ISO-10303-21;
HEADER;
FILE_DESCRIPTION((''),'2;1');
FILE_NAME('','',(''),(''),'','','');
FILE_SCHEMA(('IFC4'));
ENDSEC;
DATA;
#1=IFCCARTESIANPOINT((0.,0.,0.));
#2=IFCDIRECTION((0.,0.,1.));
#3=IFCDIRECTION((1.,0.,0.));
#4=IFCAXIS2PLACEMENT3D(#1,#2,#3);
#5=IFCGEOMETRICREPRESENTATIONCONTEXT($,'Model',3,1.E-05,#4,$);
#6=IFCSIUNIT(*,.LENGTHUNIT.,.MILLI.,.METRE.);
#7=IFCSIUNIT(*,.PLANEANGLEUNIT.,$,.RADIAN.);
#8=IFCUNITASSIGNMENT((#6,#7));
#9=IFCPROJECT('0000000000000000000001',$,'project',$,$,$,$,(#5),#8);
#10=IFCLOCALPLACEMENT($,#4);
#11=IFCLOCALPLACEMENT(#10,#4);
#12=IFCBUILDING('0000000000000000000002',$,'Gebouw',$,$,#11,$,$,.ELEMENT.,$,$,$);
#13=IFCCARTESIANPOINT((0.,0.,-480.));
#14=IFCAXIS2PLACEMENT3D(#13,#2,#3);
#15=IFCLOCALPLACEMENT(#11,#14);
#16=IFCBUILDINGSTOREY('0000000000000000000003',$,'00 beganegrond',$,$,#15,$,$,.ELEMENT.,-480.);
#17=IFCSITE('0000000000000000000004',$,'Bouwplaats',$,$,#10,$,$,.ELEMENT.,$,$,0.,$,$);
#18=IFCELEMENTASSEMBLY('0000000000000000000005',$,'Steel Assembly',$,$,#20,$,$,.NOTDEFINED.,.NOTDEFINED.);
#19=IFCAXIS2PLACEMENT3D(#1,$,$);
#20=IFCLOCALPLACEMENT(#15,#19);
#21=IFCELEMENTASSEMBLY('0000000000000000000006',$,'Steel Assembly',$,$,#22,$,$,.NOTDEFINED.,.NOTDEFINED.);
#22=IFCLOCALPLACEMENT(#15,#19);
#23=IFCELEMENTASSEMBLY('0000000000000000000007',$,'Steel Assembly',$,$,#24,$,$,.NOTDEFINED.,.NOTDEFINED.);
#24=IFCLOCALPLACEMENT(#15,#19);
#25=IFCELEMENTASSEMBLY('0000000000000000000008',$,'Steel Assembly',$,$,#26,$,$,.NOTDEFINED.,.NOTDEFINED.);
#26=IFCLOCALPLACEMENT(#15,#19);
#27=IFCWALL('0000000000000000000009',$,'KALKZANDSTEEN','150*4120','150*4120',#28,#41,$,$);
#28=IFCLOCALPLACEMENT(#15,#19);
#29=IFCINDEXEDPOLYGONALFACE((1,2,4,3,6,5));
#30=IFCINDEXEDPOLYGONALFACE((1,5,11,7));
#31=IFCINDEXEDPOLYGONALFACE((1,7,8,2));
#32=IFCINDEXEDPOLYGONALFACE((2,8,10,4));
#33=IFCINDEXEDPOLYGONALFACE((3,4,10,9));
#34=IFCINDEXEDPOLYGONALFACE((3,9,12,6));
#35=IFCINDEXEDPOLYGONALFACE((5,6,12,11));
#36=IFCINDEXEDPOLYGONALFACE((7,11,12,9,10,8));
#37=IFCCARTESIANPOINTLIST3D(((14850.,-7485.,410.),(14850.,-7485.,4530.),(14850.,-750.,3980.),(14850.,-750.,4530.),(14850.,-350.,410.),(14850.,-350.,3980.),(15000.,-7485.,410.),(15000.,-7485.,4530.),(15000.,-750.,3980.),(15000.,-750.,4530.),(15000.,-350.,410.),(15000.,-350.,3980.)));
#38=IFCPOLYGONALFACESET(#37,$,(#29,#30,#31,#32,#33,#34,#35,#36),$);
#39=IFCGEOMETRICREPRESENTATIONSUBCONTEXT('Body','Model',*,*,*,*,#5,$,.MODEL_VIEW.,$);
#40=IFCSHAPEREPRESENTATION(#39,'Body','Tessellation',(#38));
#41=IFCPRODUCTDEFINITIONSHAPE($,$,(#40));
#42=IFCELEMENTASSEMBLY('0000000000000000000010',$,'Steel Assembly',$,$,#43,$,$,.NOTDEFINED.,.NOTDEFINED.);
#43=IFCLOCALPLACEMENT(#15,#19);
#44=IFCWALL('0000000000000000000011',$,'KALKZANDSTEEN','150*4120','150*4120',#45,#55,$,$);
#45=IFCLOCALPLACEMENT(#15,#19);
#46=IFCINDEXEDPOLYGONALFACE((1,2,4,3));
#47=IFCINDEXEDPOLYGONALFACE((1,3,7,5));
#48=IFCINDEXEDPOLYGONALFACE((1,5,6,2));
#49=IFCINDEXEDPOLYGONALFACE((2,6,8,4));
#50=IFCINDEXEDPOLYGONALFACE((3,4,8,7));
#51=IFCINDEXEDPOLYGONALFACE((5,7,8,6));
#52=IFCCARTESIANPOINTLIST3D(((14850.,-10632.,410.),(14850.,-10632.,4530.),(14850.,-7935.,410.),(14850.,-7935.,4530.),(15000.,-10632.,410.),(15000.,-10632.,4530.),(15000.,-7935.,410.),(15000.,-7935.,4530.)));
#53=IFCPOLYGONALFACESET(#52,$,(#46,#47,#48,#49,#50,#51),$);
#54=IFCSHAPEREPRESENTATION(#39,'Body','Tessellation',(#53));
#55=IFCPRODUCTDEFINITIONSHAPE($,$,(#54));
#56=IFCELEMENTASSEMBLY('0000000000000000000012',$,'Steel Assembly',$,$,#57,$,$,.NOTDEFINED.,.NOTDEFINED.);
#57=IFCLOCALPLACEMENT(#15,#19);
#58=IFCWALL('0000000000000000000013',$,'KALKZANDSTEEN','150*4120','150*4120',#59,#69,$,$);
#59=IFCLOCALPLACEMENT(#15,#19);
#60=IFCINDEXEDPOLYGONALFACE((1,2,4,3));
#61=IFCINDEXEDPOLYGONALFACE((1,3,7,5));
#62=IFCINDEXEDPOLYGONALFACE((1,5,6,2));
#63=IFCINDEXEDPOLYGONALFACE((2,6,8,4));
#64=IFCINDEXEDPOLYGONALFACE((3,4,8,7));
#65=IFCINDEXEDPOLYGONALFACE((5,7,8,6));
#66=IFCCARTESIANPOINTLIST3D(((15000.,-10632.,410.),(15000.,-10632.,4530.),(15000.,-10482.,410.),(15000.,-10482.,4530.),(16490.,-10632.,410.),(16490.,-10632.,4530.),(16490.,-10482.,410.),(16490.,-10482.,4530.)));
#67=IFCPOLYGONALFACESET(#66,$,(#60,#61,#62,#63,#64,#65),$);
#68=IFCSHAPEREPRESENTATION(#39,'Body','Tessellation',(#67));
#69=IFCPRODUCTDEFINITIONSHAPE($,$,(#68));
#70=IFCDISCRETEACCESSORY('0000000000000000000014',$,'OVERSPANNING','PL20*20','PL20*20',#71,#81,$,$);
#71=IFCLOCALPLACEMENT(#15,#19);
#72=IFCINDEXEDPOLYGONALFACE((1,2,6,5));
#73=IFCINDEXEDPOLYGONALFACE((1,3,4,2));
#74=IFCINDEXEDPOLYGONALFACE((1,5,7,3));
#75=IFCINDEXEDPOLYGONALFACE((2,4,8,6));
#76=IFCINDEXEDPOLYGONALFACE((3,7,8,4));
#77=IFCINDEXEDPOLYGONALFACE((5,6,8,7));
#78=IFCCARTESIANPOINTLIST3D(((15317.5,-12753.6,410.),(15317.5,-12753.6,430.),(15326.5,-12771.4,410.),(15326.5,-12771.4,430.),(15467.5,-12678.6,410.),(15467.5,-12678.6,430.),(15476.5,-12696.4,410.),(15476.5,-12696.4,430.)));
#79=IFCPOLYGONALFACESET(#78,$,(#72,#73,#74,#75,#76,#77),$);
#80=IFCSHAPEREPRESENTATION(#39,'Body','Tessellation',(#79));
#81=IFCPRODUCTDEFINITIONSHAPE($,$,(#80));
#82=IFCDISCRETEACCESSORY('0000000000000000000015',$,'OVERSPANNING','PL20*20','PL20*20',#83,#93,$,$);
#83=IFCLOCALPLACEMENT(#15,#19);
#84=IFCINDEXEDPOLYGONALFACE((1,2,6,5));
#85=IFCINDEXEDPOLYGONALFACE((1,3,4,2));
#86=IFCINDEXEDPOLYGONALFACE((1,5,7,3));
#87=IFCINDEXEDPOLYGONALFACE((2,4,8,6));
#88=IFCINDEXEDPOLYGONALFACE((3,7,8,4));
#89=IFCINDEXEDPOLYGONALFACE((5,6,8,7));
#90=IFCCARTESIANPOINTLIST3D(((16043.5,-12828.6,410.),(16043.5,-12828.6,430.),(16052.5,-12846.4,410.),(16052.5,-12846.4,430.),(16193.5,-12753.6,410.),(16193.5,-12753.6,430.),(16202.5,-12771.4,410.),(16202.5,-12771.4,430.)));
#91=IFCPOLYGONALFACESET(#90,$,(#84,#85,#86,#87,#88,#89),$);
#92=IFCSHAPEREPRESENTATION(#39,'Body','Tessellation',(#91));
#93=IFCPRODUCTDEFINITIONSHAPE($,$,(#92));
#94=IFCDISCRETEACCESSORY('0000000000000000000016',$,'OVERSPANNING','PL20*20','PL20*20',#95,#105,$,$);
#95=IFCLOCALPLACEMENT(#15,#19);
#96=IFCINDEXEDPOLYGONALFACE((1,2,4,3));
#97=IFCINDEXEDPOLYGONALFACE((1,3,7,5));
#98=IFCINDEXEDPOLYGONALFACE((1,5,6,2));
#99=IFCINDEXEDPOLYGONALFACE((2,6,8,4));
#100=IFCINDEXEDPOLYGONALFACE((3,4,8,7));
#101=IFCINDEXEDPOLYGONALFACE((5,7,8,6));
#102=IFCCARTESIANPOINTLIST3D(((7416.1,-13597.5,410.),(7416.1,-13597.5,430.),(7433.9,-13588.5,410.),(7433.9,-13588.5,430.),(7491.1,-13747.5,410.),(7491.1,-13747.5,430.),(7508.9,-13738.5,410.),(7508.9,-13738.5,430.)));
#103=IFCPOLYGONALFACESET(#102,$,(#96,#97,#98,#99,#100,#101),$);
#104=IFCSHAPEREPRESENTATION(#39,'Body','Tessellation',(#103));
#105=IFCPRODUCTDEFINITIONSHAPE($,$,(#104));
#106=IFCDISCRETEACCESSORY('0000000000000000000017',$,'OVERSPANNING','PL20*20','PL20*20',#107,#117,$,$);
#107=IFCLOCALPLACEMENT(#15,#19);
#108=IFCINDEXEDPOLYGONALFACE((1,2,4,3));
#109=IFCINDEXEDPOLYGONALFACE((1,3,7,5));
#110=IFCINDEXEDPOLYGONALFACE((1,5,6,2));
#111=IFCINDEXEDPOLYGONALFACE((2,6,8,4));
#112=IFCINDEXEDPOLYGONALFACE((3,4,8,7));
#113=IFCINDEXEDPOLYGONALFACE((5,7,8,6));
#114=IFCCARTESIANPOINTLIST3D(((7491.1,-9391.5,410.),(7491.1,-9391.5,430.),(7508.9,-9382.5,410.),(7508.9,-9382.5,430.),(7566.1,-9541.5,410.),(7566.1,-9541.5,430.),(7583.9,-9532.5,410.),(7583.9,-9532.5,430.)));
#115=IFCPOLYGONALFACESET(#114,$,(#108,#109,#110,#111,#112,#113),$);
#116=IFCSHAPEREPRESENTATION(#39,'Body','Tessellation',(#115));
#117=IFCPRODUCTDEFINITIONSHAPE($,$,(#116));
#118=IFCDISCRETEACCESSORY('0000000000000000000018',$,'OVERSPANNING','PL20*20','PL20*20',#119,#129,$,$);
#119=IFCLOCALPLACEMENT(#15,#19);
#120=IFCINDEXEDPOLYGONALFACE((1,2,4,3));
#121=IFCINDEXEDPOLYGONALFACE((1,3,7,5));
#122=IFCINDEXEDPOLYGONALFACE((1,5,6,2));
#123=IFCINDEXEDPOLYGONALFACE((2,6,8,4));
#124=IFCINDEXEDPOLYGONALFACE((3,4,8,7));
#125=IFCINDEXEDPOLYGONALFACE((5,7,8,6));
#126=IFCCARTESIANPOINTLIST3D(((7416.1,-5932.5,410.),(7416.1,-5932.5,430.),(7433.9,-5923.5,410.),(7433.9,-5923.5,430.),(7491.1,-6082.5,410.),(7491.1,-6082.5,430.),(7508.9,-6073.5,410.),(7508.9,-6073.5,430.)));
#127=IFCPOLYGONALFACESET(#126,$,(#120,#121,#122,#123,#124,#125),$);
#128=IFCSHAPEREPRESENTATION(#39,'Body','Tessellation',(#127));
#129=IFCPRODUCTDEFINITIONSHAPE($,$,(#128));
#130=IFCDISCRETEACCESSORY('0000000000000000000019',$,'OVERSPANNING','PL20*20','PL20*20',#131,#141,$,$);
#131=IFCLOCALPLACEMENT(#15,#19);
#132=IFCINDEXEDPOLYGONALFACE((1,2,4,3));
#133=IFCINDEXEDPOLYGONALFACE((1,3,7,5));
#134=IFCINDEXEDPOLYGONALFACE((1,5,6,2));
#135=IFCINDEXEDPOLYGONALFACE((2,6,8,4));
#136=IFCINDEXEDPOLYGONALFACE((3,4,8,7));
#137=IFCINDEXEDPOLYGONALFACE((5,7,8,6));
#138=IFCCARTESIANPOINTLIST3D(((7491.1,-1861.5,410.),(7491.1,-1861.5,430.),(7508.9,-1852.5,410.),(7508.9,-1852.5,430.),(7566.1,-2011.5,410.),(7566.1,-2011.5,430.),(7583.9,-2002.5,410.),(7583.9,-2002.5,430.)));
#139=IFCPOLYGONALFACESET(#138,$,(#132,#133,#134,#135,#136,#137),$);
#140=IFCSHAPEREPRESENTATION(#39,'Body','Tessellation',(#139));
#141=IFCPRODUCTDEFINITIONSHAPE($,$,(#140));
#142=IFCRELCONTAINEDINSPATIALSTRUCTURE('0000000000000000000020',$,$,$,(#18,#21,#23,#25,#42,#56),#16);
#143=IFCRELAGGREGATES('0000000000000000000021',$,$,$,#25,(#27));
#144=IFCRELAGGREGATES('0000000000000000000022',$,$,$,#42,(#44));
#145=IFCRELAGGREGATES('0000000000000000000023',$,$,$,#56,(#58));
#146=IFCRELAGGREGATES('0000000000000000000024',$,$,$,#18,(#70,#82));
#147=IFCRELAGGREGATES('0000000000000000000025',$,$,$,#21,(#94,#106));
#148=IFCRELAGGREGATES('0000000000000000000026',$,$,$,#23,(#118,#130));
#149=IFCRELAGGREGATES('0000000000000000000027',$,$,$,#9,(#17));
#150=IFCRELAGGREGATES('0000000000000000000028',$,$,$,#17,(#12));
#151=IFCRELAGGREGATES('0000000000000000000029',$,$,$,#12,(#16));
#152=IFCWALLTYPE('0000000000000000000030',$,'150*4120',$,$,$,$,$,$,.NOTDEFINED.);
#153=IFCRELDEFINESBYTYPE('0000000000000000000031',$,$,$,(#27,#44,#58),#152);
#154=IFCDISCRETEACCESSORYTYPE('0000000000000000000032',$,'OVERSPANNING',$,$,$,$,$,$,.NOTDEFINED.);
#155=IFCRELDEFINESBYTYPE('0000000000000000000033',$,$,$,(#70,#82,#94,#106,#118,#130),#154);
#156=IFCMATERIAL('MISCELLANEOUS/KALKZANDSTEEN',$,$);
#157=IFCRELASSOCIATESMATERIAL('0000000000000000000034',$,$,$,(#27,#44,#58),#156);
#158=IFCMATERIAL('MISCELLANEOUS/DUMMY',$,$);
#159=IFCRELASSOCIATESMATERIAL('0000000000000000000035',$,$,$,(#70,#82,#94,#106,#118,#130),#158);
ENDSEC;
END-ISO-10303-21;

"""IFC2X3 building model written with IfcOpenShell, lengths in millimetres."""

from ifc_helpers import new_model, si_unit, frame, frame_2d, origin_with_axes, origin_2d_with_axis, place, context, subcontext, project, spatial, rectangle, extrude, boolean, material, type_object, element, aggregate, save


model = new_model("IFC2X3")

# Units and contexts
model_context = context("Model", 3, precision=1e-05, world=origin_with_axes())
body_context = subcontext(model_context, "Body", "Model", "MODEL_VIEW")
ifc_project = project(units=[si_unit("LENGTHUNIT", "METRE", prefix="MILLI"), si_unit("PLANEANGLEUNIT", "RADIAN")], contexts=[model_context])

# Site, building, storey
site_placement = place(None, origin_with_axes())
site = spatial("IfcSite", under=ifc_project, at=site_placement, Name="Bouwplaats", CompositionType="ELEMENT", RefElevation=0.0)
building_placement = place(site_placement, origin_with_axes())
building = spatial("IfcBuilding", under=site, at=building_placement, Name="Gebouw", CompositionType="ELEMENT")
storey_placement = place(building_placement, frame((0.0, 0.0, -480.0), z_axis=(0.0, 0.0, 1.0), x_axis=(1.0, 0.0, 0.0)))
storey = spatial("IfcBuildingStorey", under=building, at=storey_placement, Name="00 beganegrond", CompositionType="ELEMENT", Elevation=-480.0)

# Element assemblies
ifc_material_1 = material(Name="MISCELLANEOUS/DUMMY")
assembly_1_placement = place(storey_placement, origin_with_axes())
assembly_1 = element("IfcElementAssembly", 1, at=assembly_1_placement, inside=storey, Name="Steel Assembly", AssemblyPlace="NOTDEFINED", PredefinedType="NOTDEFINED")
assembly_2_placement = place(storey_placement, origin_with_axes())
assembly_2 = element("IfcElementAssembly", 2, at=assembly_2_placement, inside=storey, Name="Steel Assembly", AssemblyPlace="NOTDEFINED", PredefinedType="NOTDEFINED")
assembly_3_placement = place(storey_placement, origin_with_axes())
assembly_3 = element("IfcElementAssembly", 3, at=assembly_3_placement, inside=storey, Name="Steel Assembly", AssemblyPlace="NOTDEFINED", PredefinedType="NOTDEFINED")

# Element assemblies, walls
ifc_material_2 = material(Name="MISCELLANEOUS/KALKZANDSTEEN")
assembly_4_placement = place(storey_placement, origin_with_axes())
assembly_4 = element("IfcElementAssembly", 4, at=assembly_4_placement, inside=storey, Name="Steel Assembly", AssemblyPlace="NOTDEFINED", PredefinedType="NOTDEFINED")
wall_type_1 = type_object("IfcWallType", Name="150*4120", PredefinedType="NOTDEFINED")
wall_1_placement = place(assembly_4_placement, frame((14925.0, -7485.0, 410.0), z_axis=(0.0, 0.0, 1.0), x_axis=(0.0, 1.0, 0.0)))
wall_1 = element("IfcWall", 5, at=wall_1_placement, type_object=wall_type_1, material=ifc_material_2, Name="KALKZANDSTEEN", Description="150*4120", ObjectType="150*4120", context=body_context, shape_type="CSG", body=[
    boolean("DIFFERENCE", extrude(rectangle(XDim=7135.0, YDim=150.0, at=frame_2d((0.0, 3567.5), x_axis=(0.0, -1.0))), frame((0.0, 0.0, 0.0), z_axis=(0.0, 0.0, 1.0), x_axis=(0.0, -1.0, 0.0)), (0.0, 0.0, 1.0), 4120.0), extrude(rectangle(XDim=150.0, YDim=550.0, at=origin_2d_with_axis()), frame((6735.0, 0.0, 3845.0), z_axis=(1.0, 0.0, 0.0), x_axis=(0.0, 1.0, 0.0)), (0.0, 0.0, 1.0), 400.0)),
])
aggregate(assembly_4, [wall_1])
assembly_5_placement = place(storey_placement, origin_with_axes())
assembly_5 = element("IfcElementAssembly", 6, at=assembly_5_placement, inside=storey, Name="Steel Assembly", AssemblyPlace="NOTDEFINED", PredefinedType="NOTDEFINED")
wall_2_placement = place(assembly_5_placement, frame((14925.0, -10632.0, 410.0), z_axis=(0.0, 0.0, 1.0), x_axis=(0.0, 1.0, 0.0)))
wall_2 = element("IfcWall", 7, at=wall_2_placement, type_object=wall_type_1, material=ifc_material_2, Name="KALKZANDSTEEN", Description="150*4120", ObjectType="150*4120", context=body_context, shape_type="SweptSolid", body=[
    extrude(rectangle(XDim=2697.0, YDim=150.0, at=frame_2d((0.0, 1348.5), x_axis=(0.0, -1.0))), frame((0.0, 0.0, 0.0), z_axis=(0.0, 0.0, 1.0), x_axis=(0.0, -1.0, 0.0)), (0.0, 0.0, 1.0), 4120.0),
])
aggregate(assembly_5, [wall_2])
assembly_6_placement = place(storey_placement, origin_with_axes())
assembly_6 = element("IfcElementAssembly", 8, at=assembly_6_placement, inside=storey, Name="Steel Assembly", AssemblyPlace="NOTDEFINED", PredefinedType="NOTDEFINED")
wall_3_placement = place(assembly_6_placement, frame((15000.0, -10557.0, 410.0), z_axis=(0.0, 0.0, 1.0), x_axis=(1.0, 0.0, 0.0)))
wall_3 = element("IfcWall", 9, at=wall_3_placement, type_object=wall_type_1, material=ifc_material_2, Name="KALKZANDSTEEN", Description="150*4120", ObjectType="150*4120", context=body_context, shape_type="SweptSolid", body=[
    extrude(rectangle(XDim=1490.0, YDim=150.0, at=frame_2d((0.0, 745.0), x_axis=(0.0, -1.0))), frame((0.0, 0.0, 0.0), z_axis=(0.0, 0.0, 1.0), x_axis=(0.0, -1.0, 0.0)), (0.0, 0.0, 1.0), 4120.0),
])
aggregate(assembly_6, [wall_3])

# Discrete accessories
discrete_accessory_type = type_object("IfcDiscreteAccessoryType", Name="OVERSPANNING")
discrete_accessory_1_placement = place(assembly_1_placement, frame((15472.0, -12687.5, 420.0), z_axis=(0.447214, -0.894427, 0.0), x_axis=(-0.894427, -0.447214, 0.0)))
discrete_accessory_1 = element("IfcDiscreteAccessory", 10, at=discrete_accessory_1_placement, type_object=discrete_accessory_type, material=ifc_material_1, Name="OVERSPANNING", Description="PL20*20", ObjectType="PL20*20", context=body_context, shape_type="SweptSolid", body=[
    extrude(rectangle(XDim=20.0, YDim=20.0, at=origin_2d_with_axis()), frame((167.7, 0.0, 0.0), z_axis=(-1.0, 0.0, 0.0), x_axis=(0.0, -1.0, 0.0)), (0.0, 0.0, 1.0), 167.7),
])
discrete_accessory_2_placement = place(assembly_1_placement, frame((16048.0, -12837.5, 420.0), z_axis=(-0.447214, 0.894427, 0.0), x_axis=(0.894427, 0.447214, 0.0)))
discrete_accessory_2 = element("IfcDiscreteAccessory", 11, at=discrete_accessory_2_placement, type_object=discrete_accessory_type, material=ifc_material_1, Name="OVERSPANNING", Description="PL20*20", ObjectType="PL20*20", context=body_context, shape_type="SweptSolid", body=[
    extrude(rectangle(XDim=20.0, YDim=20.0, at=origin_2d_with_axis()), frame((167.7, 0.0, 0.0), z_axis=(-1.0, 0.0, 0.0), x_axis=(0.0, -1.0, 0.0)), (0.0, 0.0, 1.0), 167.7),
])
aggregate(assembly_1, [discrete_accessory_1, discrete_accessory_2])
discrete_accessory_3_placement = place(assembly_2_placement, frame((7425.0, -13593.0, 420.0), z_axis=(0.894427, 0.447214, 0.0), x_axis=(0.447214, -0.894427, 0.0)))
discrete_accessory_3 = element("IfcDiscreteAccessory", 12, at=discrete_accessory_3_placement, type_object=discrete_accessory_type, material=ifc_material_1, Name="OVERSPANNING", Description="PL20*20", ObjectType="PL20*20", context=body_context, shape_type="SweptSolid", body=[
    extrude(rectangle(XDim=20.0, YDim=20.0, at=origin_2d_with_axis()), frame((167.7, 0.0, 0.0), z_axis=(-1.0, 0.0, 0.0), x_axis=(0.0, -1.0, 0.0)), (0.0, 0.0, 1.0), 167.7),
])
discrete_accessory_4_placement = place(assembly_2_placement, frame((7575.0, -9537.0, 420.0), z_axis=(-0.894427, -0.447214, 0.0), x_axis=(-0.447214, 0.894427, 0.0)))
discrete_accessory_4 = element("IfcDiscreteAccessory", 13, at=discrete_accessory_4_placement, type_object=discrete_accessory_type, material=ifc_material_1, Name="OVERSPANNING", Description="PL20*20", ObjectType="PL20*20", context=body_context, shape_type="SweptSolid", body=[
    extrude(rectangle(XDim=20.0, YDim=20.0, at=origin_2d_with_axis()), frame((167.7, 0.0, 0.0), z_axis=(-1.0, 0.0, 0.0), x_axis=(0.0, -1.0, 0.0)), (0.0, 0.0, 1.0), 167.7),
])
aggregate(assembly_2, [discrete_accessory_3, discrete_accessory_4])
discrete_accessory_5_placement = place(assembly_3_placement, frame((7425.0, -5928.0, 420.0), z_axis=(0.894427, 0.447214, 0.0), x_axis=(0.447214, -0.894427, 0.0)))
discrete_accessory_5 = element("IfcDiscreteAccessory", 14, at=discrete_accessory_5_placement, type_object=discrete_accessory_type, material=ifc_material_1, Name="OVERSPANNING", Description="PL20*20", ObjectType="PL20*20", context=body_context, shape_type="SweptSolid", body=[
    extrude(rectangle(XDim=20.0, YDim=20.0, at=origin_2d_with_axis()), frame((167.7, 0.0, 0.0), z_axis=(-1.0, 0.0, 0.0), x_axis=(0.0, -1.0, 0.0)), (0.0, 0.0, 1.0), 167.7),
])
discrete_accessory_6_placement = place(assembly_3_placement, frame((7575.0, -2007.0, 420.0), z_axis=(-0.894427, -0.447214, 0.0), x_axis=(-0.447214, 0.894427, 0.0)))
discrete_accessory_6 = element("IfcDiscreteAccessory", 15, at=discrete_accessory_6_placement, type_object=discrete_accessory_type, material=ifc_material_1, Name="OVERSPANNING", Description="PL20*20", ObjectType="PL20*20", context=body_context, shape_type="SweptSolid", body=[
    extrude(rectangle(XDim=20.0, YDim=20.0, at=origin_2d_with_axis()), frame((167.7, 0.0, 0.0), z_axis=(-1.0, 0.0, 0.0), x_axis=(0.0, -1.0, 0.0)), (0.0, 0.0, 1.0), 167.7),
])
aggregate(assembly_3, [discrete_accessory_5, discrete_accessory_6])

save(model, "model.ifc")
